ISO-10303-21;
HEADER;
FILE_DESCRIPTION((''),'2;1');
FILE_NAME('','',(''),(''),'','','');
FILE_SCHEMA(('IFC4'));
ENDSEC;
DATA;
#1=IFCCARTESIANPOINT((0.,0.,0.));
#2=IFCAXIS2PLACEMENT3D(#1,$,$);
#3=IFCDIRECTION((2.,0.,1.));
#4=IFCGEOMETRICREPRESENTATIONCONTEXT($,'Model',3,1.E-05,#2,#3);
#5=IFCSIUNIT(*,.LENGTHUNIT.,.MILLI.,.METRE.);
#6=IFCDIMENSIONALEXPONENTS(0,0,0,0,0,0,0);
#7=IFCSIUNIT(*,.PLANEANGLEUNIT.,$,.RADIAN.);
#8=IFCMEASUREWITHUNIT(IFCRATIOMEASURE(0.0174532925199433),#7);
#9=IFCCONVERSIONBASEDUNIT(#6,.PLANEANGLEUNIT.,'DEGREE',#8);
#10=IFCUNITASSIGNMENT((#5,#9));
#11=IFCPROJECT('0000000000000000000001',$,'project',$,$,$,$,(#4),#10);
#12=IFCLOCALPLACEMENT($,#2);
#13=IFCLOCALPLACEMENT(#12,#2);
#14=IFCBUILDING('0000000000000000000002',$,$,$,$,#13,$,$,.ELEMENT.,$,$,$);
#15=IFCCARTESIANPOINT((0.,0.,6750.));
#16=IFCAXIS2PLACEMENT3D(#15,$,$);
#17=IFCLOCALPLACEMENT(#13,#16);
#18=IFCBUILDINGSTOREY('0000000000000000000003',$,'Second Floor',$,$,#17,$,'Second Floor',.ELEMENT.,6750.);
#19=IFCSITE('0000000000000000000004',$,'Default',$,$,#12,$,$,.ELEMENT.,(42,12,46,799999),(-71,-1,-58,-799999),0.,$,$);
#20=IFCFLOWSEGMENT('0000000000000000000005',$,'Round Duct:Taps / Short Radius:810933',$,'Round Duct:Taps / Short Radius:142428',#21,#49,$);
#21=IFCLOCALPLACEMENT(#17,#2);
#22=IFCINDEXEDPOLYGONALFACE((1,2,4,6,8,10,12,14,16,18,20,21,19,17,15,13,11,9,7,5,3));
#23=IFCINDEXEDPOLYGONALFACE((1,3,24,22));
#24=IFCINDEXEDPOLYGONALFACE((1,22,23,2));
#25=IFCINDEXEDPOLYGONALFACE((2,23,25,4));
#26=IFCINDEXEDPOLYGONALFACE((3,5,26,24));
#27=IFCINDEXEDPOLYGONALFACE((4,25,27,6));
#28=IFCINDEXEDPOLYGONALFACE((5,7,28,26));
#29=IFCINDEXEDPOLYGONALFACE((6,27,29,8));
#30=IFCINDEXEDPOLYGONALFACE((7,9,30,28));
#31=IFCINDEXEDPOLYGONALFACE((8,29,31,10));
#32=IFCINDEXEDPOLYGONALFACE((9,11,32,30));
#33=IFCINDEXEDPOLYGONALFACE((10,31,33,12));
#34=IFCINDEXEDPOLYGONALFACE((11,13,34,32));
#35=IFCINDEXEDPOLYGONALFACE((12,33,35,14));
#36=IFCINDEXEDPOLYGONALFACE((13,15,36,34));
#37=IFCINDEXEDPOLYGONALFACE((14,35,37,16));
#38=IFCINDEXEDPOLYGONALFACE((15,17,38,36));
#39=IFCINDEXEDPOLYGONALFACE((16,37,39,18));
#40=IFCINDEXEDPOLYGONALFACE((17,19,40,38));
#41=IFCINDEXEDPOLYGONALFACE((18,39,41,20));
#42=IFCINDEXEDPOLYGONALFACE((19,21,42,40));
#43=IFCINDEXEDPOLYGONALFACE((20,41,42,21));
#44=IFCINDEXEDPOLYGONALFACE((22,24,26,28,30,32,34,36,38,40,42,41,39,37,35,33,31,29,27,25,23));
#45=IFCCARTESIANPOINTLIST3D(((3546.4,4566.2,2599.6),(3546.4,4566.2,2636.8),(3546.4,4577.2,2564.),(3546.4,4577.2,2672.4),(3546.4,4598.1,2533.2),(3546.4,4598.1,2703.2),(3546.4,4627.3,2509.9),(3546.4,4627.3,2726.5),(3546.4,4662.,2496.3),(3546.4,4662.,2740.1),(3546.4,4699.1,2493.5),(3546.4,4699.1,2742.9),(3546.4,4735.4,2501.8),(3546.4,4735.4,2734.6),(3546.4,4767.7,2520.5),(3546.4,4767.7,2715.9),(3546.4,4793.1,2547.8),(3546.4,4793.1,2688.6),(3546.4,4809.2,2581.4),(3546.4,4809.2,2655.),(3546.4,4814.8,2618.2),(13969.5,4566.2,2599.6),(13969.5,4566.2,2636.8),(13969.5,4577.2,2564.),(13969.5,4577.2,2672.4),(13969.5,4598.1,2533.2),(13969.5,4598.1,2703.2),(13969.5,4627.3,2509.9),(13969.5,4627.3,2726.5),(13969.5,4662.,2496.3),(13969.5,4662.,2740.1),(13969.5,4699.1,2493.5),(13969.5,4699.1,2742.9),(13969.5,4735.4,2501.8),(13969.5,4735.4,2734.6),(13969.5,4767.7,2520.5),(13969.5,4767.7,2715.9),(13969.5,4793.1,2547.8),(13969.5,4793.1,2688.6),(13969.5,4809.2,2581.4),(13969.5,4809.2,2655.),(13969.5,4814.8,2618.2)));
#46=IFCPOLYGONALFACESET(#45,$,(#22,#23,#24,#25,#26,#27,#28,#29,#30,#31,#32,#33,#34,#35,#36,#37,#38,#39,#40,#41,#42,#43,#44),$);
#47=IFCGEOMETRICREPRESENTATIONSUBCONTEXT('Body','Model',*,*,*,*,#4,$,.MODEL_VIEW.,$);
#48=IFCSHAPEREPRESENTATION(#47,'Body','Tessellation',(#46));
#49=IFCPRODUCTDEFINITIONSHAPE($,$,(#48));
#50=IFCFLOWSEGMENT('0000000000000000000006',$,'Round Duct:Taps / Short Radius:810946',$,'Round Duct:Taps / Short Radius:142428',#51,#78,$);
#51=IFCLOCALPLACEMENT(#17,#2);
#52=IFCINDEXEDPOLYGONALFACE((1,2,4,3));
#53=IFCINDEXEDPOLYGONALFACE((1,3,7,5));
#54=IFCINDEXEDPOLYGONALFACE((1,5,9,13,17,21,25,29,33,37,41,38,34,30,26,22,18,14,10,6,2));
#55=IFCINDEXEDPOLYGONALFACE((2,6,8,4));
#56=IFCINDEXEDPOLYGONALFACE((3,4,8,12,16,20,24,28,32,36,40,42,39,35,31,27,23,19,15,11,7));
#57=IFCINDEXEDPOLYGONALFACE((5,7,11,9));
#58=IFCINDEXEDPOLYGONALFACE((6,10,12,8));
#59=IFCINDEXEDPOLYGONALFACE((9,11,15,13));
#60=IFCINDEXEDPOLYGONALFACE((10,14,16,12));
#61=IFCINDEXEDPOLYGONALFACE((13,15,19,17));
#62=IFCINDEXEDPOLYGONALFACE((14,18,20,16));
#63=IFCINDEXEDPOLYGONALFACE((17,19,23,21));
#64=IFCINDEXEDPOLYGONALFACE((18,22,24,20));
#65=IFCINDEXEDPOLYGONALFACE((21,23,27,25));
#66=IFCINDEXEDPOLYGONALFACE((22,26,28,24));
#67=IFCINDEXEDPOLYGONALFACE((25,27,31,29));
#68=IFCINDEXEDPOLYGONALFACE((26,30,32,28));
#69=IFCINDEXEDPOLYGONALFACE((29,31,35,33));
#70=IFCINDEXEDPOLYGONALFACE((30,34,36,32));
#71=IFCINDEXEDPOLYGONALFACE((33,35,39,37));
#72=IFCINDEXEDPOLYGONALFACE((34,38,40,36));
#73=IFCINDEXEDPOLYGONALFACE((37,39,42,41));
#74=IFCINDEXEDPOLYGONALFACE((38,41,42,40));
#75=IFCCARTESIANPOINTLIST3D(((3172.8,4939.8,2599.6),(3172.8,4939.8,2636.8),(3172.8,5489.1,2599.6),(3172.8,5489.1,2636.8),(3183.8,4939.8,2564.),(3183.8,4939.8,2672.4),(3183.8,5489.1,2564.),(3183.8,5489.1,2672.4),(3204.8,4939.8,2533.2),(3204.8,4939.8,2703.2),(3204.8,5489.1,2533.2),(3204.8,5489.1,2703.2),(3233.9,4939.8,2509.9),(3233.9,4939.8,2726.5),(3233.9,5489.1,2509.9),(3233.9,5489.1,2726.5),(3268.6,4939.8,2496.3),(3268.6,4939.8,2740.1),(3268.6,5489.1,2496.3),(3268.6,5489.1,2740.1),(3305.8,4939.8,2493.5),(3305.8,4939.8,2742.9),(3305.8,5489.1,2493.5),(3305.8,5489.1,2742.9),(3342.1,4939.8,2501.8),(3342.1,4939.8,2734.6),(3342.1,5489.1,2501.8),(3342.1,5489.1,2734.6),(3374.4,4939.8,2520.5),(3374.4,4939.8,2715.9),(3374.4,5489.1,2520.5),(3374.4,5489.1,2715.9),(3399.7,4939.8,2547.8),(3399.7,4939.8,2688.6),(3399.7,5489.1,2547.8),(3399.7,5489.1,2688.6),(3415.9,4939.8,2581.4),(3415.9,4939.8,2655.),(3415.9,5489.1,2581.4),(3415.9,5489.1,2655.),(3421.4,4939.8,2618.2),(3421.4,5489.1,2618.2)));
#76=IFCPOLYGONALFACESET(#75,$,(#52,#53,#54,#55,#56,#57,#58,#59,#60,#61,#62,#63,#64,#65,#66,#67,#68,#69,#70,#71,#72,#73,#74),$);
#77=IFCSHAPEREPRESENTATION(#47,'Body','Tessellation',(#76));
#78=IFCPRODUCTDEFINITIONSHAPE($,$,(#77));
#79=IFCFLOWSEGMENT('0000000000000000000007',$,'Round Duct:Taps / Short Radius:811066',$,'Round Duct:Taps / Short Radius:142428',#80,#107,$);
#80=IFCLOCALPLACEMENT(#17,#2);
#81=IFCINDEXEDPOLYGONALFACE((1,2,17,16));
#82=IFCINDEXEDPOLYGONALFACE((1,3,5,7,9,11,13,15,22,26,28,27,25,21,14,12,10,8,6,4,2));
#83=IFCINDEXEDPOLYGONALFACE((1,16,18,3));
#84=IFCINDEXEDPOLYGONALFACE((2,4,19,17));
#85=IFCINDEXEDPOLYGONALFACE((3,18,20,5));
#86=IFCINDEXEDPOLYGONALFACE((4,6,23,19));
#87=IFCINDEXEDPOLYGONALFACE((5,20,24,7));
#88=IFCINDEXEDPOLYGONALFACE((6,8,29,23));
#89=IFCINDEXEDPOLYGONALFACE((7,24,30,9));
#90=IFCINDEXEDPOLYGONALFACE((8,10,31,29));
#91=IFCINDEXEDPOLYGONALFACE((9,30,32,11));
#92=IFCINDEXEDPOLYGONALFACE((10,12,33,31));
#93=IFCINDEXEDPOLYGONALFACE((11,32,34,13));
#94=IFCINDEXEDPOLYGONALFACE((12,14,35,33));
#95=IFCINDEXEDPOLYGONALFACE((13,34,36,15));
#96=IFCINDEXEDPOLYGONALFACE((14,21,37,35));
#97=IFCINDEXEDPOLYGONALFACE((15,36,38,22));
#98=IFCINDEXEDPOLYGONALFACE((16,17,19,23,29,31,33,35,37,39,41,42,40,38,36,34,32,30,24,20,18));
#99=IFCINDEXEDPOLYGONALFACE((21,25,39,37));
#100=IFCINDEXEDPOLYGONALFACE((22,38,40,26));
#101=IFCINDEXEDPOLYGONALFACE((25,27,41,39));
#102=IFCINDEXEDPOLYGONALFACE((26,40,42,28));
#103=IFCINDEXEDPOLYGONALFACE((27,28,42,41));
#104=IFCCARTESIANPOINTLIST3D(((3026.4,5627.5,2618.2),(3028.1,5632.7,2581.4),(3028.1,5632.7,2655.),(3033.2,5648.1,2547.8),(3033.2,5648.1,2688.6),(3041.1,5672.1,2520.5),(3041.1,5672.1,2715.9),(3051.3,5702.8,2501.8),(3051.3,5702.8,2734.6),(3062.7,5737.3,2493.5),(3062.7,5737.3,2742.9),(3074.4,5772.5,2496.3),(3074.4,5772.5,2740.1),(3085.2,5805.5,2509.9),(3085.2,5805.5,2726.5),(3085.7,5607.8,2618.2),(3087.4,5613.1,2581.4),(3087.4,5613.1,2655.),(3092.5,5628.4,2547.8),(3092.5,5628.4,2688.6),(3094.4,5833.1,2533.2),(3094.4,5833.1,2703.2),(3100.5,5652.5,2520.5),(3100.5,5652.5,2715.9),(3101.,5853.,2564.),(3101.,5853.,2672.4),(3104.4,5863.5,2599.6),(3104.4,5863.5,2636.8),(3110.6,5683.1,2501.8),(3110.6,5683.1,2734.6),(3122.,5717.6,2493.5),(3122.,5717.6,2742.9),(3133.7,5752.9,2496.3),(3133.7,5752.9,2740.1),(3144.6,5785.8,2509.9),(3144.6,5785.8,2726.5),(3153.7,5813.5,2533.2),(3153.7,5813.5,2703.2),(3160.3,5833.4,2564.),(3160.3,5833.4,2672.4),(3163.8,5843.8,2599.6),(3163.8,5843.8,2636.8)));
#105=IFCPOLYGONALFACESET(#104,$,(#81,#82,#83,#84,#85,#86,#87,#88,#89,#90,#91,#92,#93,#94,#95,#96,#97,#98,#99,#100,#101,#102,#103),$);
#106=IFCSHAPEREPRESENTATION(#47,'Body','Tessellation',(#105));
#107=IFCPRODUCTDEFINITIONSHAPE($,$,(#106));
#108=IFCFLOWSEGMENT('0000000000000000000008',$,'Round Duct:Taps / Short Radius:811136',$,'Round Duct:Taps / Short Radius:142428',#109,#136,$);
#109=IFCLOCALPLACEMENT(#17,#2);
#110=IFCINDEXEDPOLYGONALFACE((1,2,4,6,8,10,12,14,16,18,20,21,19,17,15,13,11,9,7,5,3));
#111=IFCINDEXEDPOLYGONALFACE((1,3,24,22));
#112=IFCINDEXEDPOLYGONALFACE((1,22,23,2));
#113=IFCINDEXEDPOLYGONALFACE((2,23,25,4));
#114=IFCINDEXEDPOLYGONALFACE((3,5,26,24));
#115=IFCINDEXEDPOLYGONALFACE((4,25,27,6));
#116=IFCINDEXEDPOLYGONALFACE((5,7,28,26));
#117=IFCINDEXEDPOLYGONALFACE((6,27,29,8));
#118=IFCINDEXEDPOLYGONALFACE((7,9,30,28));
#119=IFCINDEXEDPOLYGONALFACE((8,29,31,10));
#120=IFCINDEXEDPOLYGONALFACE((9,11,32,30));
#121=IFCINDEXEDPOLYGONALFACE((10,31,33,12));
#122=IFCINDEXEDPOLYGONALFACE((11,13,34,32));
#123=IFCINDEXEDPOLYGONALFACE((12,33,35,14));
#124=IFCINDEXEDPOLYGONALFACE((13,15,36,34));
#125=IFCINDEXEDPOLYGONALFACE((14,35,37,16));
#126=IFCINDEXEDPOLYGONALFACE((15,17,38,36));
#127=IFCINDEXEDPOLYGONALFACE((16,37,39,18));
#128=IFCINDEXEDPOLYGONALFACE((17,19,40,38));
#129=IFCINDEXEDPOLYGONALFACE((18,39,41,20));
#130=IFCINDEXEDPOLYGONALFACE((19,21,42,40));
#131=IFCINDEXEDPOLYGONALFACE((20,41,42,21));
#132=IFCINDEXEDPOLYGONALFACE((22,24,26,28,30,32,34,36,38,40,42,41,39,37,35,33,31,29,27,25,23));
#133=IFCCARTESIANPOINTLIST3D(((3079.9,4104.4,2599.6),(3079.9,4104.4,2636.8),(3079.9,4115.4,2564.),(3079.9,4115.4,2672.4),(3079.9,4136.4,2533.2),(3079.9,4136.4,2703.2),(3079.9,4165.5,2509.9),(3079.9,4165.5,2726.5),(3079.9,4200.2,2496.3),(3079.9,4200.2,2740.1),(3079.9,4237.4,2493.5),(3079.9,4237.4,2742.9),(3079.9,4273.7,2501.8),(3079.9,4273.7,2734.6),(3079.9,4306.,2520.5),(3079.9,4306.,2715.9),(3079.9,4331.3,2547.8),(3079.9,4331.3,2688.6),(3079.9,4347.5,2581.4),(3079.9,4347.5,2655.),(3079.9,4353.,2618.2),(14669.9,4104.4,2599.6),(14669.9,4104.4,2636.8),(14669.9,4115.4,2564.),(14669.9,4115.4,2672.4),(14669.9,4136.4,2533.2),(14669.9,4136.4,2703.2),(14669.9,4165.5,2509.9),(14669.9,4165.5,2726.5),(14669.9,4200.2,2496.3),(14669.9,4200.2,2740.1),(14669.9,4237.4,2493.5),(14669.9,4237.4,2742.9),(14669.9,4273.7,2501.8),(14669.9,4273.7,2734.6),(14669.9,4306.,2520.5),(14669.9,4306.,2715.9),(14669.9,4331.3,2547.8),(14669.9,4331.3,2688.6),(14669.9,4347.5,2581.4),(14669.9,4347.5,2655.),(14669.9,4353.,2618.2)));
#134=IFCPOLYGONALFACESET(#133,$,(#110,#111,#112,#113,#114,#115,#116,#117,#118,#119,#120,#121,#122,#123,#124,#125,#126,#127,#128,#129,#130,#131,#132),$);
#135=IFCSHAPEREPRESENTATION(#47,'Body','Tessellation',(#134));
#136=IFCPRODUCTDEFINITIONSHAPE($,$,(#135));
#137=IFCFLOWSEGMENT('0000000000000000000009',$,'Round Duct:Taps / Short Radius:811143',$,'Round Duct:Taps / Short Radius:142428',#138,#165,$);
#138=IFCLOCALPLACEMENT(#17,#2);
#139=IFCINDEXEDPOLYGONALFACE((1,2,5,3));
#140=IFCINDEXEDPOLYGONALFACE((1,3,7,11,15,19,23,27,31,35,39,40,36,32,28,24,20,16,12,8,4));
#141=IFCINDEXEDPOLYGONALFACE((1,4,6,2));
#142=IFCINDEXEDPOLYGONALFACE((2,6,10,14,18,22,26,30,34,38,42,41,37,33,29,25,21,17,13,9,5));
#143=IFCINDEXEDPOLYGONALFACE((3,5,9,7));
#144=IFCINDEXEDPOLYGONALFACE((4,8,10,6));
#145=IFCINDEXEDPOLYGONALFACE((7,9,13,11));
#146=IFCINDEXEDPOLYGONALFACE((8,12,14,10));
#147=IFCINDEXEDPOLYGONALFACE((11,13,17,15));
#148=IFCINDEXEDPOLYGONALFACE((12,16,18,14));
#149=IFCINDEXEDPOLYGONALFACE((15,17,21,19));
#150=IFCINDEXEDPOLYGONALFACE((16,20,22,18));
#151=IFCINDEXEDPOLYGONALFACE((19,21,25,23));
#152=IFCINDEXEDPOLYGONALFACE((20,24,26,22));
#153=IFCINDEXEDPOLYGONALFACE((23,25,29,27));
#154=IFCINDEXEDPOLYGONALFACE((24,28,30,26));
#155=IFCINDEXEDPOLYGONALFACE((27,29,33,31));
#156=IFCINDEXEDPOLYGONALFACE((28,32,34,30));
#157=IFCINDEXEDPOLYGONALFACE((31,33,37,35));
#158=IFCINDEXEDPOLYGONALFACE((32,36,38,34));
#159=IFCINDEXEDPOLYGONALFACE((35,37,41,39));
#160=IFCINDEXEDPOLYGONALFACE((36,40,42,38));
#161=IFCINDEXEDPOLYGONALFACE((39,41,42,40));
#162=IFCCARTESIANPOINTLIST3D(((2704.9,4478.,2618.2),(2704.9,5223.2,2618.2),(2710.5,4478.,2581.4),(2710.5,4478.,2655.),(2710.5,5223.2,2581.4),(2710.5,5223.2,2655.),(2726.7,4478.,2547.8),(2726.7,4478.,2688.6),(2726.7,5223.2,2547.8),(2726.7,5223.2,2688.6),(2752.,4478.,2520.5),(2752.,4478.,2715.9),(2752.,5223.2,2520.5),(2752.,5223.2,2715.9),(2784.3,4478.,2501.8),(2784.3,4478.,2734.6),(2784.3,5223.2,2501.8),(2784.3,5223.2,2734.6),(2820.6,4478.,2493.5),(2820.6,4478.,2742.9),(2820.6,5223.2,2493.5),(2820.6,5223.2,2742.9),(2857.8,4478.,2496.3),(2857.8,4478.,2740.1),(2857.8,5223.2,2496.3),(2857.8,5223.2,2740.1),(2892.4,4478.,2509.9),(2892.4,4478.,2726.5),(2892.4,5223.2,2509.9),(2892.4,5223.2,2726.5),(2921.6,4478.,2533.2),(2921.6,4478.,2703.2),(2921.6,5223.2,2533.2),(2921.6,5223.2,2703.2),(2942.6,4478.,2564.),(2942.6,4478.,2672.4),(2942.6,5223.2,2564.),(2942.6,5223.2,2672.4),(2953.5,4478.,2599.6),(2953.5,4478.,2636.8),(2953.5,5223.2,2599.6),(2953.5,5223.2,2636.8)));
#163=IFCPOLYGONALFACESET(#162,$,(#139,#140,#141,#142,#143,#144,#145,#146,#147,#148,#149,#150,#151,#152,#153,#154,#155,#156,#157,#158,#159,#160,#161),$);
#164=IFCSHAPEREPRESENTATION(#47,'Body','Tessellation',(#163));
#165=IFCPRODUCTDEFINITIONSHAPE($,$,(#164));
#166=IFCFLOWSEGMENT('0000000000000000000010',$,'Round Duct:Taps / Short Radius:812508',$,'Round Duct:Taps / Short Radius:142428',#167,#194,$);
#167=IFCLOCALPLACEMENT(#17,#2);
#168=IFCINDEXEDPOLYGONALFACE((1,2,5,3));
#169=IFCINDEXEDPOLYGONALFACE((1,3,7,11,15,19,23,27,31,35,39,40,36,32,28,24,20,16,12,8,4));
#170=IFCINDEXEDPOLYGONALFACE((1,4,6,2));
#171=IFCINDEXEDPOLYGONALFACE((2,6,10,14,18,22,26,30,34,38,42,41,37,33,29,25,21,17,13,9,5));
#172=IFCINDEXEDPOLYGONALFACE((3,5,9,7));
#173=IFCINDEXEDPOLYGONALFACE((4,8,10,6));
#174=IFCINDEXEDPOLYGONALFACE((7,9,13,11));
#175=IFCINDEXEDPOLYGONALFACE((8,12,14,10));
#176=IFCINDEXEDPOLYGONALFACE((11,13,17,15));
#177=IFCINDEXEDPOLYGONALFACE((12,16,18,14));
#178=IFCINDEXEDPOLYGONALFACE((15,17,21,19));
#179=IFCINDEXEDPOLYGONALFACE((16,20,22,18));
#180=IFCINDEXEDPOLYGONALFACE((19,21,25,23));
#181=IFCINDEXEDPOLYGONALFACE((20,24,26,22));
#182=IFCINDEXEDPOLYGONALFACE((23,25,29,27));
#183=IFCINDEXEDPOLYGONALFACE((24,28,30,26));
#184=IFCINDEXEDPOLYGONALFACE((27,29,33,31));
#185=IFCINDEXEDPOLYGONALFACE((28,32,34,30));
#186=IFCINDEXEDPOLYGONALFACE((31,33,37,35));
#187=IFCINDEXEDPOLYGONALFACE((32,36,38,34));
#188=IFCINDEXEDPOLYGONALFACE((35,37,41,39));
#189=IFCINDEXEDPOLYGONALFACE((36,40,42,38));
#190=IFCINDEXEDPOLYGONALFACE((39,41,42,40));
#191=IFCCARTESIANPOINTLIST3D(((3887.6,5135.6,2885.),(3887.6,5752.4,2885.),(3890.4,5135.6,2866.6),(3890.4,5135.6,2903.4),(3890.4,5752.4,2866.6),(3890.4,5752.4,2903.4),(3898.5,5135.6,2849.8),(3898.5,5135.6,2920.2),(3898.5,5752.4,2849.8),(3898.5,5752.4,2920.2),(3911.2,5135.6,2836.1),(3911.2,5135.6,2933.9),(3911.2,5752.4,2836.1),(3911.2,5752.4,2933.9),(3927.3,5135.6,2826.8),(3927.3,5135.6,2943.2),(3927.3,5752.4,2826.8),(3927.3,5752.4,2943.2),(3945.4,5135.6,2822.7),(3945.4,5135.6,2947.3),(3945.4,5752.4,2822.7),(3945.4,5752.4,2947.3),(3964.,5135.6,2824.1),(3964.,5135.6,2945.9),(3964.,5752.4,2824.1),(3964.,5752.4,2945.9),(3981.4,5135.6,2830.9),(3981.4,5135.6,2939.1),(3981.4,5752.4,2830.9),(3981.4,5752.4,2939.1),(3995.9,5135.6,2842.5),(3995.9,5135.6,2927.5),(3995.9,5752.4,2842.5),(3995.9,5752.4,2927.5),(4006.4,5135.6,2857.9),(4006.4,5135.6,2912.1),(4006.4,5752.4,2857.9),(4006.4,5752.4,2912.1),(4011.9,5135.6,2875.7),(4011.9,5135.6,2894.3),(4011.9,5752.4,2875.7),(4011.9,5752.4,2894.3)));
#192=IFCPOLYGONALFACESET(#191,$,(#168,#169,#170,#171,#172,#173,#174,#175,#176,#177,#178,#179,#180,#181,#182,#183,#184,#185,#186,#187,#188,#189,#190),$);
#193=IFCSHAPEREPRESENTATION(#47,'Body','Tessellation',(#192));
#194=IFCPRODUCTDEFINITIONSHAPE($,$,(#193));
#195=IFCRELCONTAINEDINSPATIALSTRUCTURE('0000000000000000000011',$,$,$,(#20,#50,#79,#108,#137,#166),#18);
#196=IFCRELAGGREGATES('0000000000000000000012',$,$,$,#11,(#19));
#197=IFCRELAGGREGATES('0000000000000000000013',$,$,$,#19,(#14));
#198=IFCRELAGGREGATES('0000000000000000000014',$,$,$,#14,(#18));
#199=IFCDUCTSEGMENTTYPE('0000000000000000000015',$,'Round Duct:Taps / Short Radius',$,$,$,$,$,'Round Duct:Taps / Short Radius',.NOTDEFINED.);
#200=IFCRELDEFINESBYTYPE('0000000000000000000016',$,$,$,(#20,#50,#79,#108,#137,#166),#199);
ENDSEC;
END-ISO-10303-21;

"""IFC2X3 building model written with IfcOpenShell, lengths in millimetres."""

from ifc_helpers import new_model, entity, si_unit, converted_unit, direction, frame, frame_2d, origin, origin_2d_with_axis, place, context, subcontext, project, spatial, circle, extrude, type_object, element, save


model = new_model("IFC2X3")

# Units and contexts
model_context = context("Model", 3, precision=1e-05, world=origin(), true_north=direction((2.0, 0.0, 1.0)))
body_context = subcontext(model_context, "Body", "Model", "MODEL_VIEW")
ifc_project = project(units=[si_unit("LENGTHUNIT", "METRE", prefix="MILLI"), converted_unit("PLANEANGLEUNIT", "DEGREE", entity("IfcRatioMeasure", 0.0174532925199433), si_unit("PLANEANGLEUNIT", "RADIAN"), dimensions=[0, 0, 0, 0, 0, 0, 0])], contexts=[model_context])

# Site, building, storey
site_placement = place(None, origin())
site = spatial("IfcSite", under=ifc_project, at=site_placement, Name="Default", CompositionType="ELEMENT", RefLatitude=(42, 12, 46, 799999), RefLongitude=(-71, -1, -58, -799999), RefElevation=0.0)
building_placement = place(site_placement, origin())
building = spatial("IfcBuilding", under=site, at=building_placement, CompositionType="ELEMENT")
storey_placement = place(building_placement, frame((0.0, 0.0, 6750.0)))
storey = spatial("IfcBuildingStorey", under=building, at=storey_placement, Name="Second Floor", LongName="Second Floor", CompositionType="ELEMENT", Elevation=6750.0)

# Flow segments
duct_segment_type = type_object("IfcDuctSegmentType", Name="Round Duct:Taps / Short Radius", ElementType="Round Duct:Taps / Short Radius", PredefinedType="NOTDEFINED")
flow_segment_1_placement = place(storey_placement, origin())
element("IfcFlowSegment", 1, at=flow_segment_1_placement, inside=storey, type_object=duct_segment_type, Name="Round Duct:Taps / Short Radius:810933", ObjectType="Round Duct:Taps / Short Radius:142428", context=body_context, shape_type="SweptSolid", body=[
    extrude(circle(Radius=125.0, at=frame_2d((0.0, 0.0), x_axis=(1.0, 0.0))), frame((3546.4, 4689.8, 2618.2), z_axis=(1.0, 0.0, 0.0), x_axis=(0.0, 1.0, 0.0)), (0.0, 0.0, 1.0), 10423.1),
])
flow_segment_2_placement = place(storey_placement, origin())
element("IfcFlowSegment", 2, at=flow_segment_2_placement, inside=storey, type_object=duct_segment_type, Name="Round Duct:Taps / Short Radius:810946", ObjectType="Round Duct:Taps / Short Radius:142428", context=body_context, shape_type="SweptSolid", body=[
    extrude(circle(Radius=125.0, at=origin_2d_with_axis()), frame((3296.4, 4939.8, 2618.2), z_axis=(0.0, 1.0, 0.0), x_axis=(1.0, 0.0, 0.0)), (0.0, 0.0, 1.0), 549.4),
])
flow_segment_3_placement = place(storey_placement, origin())
element("IfcFlowSegment", 3, at=flow_segment_3_placement, inside=storey, type_object=duct_segment_type, Name="Round Duct:Taps / Short Radius:811066", ObjectType="Round Duct:Taps / Short Radius:142428", context=body_context, shape_type="SweptSolid", body=[
    extrude(circle(Radius=125.0, at=origin_2d_with_axis()), frame((3124.9, 5726.5, 2618.2), z_axis=(-0.949402, 0.314062, 0.0), x_axis=(-0.314062, -0.949402, 0.0)), (0.0, 0.0, 1.0), 62.5),
])
flow_segment_4_placement = place(storey_placement, origin())
element("IfcFlowSegment", 4, at=flow_segment_4_placement, inside=storey, type_object=duct_segment_type, Name="Round Duct:Taps / Short Radius:811136", ObjectType="Round Duct:Taps / Short Radius:142428", context=body_context, shape_type="SweptSolid", body=[
    extrude(circle(Radius=125.0, at=frame_2d((0.0, 0.0), x_axis=(1.0, 0.0))), frame((3079.9, 4228.0, 2618.2), z_axis=(1.0, 0.0, 0.0), x_axis=(0.0, 1.0, 0.0)), (0.0, 0.0, 1.0), 11589.9),
])
flow_segment_5_placement = place(storey_placement, origin())
element("IfcFlowSegment", 5, at=flow_segment_5_placement, inside=storey, type_object=duct_segment_type, Name="Round Duct:Taps / Short Radius:811143", ObjectType="Round Duct:Taps / Short Radius:142428", context=body_context, shape_type="SweptSolid", body=[
    extrude(circle(Radius=125.0, at=frame_2d((0.0, 0.0), x_axis=(1.0, 0.0))), frame((2829.9, 4478.0, 2618.2), z_axis=(0.0, 1.0, 0.0), x_axis=(-1.0, 0.0, 0.0)), (0.0, 0.0, 1.0), 745.2),
])
flow_segment_6_placement = place(storey_placement, origin())
element("IfcFlowSegment", 6, at=flow_segment_6_placement, inside=storey, type_object=duct_segment_type, Name="Round Duct:Taps / Short Radius:812508", ObjectType="Round Duct:Taps / Short Radius:142428", context=body_context, shape_type="SweptSolid", body=[
    extrude(circle(Radius=62.5, at=frame_2d((0.0, 0.0), x_axis=(1.0, 0.0))), frame((3950.1, 5135.6, 2885.0), z_axis=(0.0, 1.0, 0.0), x_axis=(-1.0, 0.0, 0.0)), (0.0, 0.0, 1.0), 616.8),
])

save(model, "model.ifc")
